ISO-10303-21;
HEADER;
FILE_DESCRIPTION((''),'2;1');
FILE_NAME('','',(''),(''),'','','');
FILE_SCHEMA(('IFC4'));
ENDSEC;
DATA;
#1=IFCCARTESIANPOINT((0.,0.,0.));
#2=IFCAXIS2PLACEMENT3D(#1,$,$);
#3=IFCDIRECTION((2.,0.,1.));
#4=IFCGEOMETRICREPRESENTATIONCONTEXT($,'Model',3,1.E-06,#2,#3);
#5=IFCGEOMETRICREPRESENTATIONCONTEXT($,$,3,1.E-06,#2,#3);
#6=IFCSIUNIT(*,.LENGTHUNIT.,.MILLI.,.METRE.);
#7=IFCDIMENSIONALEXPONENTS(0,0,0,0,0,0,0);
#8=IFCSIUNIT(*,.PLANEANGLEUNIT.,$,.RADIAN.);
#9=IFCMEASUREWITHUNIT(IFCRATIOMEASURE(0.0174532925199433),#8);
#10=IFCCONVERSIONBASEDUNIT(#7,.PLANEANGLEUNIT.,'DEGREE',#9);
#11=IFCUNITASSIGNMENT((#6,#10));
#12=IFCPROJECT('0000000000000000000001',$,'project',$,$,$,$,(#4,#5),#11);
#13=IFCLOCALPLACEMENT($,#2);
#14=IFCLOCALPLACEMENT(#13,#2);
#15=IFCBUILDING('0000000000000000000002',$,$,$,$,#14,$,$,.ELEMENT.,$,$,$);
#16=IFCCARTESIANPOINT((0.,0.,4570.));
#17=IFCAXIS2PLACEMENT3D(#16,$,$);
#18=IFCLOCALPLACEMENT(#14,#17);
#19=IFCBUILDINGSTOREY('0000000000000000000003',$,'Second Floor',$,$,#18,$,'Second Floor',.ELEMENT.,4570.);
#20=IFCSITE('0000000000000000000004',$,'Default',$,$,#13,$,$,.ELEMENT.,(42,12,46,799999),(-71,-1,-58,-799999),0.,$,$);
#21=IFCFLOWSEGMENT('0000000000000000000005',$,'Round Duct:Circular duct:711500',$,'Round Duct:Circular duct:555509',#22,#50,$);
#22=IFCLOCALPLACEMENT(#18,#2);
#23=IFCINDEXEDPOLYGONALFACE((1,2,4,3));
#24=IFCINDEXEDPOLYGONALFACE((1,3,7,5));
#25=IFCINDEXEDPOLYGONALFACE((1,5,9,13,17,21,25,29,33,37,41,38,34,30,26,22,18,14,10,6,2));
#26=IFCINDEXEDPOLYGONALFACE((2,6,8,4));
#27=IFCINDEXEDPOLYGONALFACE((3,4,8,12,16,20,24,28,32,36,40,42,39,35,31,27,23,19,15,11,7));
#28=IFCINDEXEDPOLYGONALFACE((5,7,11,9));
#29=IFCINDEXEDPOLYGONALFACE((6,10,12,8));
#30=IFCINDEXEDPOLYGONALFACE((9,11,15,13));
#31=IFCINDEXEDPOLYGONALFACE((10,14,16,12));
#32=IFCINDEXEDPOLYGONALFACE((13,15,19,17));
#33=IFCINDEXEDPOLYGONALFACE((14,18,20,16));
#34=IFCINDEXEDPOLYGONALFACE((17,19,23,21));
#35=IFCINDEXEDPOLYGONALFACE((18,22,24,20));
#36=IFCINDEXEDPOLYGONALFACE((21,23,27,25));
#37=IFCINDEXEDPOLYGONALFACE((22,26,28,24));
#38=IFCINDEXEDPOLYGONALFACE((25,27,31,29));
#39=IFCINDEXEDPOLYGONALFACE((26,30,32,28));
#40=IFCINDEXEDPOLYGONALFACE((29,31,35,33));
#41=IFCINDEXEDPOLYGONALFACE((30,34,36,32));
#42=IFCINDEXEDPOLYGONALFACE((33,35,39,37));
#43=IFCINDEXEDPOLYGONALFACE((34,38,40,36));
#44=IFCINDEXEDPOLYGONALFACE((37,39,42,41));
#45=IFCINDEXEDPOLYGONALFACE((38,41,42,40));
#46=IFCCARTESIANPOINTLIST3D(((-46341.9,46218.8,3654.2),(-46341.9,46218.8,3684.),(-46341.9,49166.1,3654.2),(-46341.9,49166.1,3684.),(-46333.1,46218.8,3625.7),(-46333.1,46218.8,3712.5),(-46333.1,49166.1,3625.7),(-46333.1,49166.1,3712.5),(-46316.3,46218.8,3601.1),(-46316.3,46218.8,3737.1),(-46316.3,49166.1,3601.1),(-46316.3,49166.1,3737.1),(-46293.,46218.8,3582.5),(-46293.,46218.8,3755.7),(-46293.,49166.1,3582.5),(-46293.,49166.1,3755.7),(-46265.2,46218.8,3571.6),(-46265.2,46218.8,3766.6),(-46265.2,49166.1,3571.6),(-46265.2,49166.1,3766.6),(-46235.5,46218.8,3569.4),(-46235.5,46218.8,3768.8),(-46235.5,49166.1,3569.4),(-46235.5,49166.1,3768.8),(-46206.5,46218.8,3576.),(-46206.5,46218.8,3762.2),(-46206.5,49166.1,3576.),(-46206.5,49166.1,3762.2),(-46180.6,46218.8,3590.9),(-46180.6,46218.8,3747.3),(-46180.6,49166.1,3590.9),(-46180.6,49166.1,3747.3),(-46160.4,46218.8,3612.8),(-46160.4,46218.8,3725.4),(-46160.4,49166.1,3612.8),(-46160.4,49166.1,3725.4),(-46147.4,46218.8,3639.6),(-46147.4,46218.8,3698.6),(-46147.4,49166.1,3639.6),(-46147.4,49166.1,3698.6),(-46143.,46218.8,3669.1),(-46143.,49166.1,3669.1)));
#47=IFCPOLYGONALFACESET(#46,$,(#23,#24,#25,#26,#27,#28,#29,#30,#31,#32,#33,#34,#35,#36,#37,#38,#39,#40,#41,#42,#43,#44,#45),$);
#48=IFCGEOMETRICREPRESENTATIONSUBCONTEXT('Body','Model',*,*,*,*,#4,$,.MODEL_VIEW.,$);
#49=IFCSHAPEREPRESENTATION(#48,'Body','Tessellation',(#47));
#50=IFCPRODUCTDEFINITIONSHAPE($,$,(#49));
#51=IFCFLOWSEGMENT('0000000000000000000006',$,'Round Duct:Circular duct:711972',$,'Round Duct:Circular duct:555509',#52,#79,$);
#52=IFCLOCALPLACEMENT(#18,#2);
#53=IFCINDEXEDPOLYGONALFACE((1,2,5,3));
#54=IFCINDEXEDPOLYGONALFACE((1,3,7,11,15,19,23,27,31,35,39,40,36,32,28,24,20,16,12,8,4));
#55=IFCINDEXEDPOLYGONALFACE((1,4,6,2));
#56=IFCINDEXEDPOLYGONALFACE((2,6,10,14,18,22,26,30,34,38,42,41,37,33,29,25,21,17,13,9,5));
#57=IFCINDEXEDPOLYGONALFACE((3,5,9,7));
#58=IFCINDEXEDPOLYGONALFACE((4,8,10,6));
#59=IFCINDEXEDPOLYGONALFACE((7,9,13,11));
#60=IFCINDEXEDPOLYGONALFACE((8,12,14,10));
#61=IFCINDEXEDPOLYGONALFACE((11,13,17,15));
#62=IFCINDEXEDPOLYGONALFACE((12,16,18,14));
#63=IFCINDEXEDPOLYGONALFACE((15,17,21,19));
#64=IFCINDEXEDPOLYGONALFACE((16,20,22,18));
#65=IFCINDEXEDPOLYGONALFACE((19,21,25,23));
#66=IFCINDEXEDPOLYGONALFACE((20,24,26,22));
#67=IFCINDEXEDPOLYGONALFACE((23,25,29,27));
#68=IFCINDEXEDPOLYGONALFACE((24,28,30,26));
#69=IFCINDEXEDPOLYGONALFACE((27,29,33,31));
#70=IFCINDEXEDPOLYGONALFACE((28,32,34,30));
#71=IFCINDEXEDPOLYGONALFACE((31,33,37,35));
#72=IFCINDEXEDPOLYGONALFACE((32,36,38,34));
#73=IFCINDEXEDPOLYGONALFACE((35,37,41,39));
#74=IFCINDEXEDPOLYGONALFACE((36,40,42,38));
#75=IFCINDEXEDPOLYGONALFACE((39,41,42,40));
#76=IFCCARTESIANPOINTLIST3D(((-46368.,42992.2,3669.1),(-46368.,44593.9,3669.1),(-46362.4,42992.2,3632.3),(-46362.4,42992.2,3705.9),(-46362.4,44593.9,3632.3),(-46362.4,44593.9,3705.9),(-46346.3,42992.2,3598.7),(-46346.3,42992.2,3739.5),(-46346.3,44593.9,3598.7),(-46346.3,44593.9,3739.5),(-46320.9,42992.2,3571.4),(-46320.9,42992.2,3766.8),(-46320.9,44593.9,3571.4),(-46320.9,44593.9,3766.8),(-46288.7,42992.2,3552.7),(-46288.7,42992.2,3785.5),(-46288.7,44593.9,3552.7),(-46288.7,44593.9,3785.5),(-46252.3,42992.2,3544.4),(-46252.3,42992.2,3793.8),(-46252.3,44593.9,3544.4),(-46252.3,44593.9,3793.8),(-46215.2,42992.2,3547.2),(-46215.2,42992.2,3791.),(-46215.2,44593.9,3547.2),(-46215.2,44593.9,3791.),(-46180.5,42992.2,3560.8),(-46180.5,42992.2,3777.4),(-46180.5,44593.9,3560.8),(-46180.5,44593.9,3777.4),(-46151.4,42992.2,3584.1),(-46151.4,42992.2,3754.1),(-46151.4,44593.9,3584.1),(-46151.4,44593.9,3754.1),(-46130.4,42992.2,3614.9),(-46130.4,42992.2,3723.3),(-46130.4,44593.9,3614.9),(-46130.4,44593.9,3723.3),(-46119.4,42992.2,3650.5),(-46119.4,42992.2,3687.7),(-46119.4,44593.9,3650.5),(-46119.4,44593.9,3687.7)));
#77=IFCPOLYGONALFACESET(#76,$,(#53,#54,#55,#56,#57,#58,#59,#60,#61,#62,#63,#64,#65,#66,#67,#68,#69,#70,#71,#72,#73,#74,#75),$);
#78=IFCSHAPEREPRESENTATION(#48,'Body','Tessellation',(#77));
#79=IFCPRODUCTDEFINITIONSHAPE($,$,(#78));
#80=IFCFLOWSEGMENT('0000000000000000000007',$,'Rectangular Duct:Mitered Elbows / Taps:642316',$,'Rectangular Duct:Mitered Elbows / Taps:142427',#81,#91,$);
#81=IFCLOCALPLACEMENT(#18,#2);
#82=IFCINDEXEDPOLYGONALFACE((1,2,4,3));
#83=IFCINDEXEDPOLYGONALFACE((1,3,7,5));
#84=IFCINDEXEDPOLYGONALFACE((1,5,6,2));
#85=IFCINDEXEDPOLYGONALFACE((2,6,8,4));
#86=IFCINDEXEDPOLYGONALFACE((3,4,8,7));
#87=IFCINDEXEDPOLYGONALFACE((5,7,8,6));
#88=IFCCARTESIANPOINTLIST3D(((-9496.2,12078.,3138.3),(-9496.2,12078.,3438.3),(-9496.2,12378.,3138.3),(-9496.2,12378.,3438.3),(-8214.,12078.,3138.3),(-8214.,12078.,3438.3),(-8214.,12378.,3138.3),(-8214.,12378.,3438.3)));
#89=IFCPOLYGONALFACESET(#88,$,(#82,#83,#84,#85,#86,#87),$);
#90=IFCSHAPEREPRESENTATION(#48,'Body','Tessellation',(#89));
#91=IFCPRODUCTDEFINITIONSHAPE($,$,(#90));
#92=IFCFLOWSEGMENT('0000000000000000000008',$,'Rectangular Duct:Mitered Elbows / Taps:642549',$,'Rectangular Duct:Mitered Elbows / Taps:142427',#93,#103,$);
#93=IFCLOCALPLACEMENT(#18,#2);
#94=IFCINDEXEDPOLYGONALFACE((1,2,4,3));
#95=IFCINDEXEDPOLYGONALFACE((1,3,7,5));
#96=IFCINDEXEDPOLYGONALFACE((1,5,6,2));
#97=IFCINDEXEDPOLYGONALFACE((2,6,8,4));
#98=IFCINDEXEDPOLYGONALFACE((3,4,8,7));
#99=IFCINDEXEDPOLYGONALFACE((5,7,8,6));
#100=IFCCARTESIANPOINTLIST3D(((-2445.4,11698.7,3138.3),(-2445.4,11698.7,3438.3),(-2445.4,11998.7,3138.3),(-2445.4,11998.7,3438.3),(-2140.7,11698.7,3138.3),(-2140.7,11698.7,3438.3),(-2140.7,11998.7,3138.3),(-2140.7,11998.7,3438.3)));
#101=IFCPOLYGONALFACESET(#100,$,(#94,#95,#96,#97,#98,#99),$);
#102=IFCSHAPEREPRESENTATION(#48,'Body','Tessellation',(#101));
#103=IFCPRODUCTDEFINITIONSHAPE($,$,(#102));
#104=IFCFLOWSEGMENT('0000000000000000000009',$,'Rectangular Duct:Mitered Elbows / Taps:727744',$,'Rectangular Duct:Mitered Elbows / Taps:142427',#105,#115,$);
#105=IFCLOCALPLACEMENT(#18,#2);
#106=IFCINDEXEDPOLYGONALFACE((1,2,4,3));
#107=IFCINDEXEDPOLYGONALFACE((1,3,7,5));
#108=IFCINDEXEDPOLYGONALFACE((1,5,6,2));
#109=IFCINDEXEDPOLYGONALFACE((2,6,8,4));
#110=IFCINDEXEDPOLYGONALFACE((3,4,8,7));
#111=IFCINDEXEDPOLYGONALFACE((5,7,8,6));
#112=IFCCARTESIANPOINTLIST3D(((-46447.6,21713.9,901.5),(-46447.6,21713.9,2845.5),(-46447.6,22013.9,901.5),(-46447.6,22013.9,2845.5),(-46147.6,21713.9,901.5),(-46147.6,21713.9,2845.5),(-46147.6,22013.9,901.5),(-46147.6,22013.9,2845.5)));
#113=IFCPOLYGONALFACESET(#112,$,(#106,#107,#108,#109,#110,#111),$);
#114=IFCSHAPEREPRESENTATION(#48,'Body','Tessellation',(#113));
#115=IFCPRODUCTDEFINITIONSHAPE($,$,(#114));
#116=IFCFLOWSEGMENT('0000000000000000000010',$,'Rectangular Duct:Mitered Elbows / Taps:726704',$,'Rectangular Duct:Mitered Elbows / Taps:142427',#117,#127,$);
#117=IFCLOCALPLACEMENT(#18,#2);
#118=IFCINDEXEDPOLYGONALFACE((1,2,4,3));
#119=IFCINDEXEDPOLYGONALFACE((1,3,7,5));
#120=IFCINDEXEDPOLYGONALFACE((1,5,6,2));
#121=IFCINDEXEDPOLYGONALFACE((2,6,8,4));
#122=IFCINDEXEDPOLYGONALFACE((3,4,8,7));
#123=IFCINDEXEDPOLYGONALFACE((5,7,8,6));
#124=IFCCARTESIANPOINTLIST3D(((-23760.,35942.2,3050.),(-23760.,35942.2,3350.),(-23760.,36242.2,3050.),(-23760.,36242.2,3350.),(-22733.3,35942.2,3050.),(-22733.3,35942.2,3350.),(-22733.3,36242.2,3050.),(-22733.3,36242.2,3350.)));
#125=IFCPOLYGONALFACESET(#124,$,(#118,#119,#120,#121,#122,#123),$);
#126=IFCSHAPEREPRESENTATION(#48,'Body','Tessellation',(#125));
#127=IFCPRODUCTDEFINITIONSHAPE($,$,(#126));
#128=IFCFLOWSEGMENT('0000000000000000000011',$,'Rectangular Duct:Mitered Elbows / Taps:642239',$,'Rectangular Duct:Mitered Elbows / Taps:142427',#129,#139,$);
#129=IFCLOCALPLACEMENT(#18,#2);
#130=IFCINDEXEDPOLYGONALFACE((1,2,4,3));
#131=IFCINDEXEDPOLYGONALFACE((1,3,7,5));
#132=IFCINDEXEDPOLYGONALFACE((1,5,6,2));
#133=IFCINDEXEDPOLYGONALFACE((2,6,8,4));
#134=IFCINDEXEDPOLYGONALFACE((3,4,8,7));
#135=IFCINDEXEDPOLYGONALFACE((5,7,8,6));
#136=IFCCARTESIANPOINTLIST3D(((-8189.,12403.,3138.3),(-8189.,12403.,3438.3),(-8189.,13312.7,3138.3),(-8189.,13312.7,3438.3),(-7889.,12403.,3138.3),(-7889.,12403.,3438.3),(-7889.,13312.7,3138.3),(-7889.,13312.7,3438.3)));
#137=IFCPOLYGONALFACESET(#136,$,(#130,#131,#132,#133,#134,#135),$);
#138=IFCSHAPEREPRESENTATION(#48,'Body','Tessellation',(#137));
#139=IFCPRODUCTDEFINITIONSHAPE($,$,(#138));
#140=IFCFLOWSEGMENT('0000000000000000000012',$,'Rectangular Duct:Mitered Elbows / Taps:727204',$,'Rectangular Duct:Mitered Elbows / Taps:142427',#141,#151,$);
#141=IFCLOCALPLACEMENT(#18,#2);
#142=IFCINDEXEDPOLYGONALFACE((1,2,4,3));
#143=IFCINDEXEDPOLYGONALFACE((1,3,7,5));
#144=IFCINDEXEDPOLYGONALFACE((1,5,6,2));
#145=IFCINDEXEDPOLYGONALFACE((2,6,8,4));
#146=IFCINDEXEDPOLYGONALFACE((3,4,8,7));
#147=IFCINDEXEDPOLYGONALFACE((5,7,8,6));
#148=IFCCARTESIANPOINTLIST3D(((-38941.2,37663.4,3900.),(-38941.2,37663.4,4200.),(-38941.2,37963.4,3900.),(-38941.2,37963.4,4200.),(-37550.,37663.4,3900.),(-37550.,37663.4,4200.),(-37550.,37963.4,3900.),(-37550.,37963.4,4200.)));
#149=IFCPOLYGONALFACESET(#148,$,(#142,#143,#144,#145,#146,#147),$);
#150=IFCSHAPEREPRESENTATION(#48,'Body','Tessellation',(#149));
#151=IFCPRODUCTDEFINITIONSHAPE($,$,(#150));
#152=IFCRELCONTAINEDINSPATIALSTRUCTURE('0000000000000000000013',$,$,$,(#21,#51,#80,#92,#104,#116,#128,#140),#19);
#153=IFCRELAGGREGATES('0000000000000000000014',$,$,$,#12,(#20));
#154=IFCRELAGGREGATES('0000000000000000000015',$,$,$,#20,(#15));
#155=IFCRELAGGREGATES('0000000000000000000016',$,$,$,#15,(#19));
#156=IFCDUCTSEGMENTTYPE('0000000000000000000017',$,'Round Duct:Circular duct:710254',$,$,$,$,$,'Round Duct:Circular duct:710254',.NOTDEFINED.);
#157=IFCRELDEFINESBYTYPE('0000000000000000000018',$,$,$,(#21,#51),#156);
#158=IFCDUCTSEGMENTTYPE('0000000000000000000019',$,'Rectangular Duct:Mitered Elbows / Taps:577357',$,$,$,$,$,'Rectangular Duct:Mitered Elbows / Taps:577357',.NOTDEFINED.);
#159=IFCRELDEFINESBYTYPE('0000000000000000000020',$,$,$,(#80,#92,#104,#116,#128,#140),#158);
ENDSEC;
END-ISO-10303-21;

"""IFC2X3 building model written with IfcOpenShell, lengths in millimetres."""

from ifc_helpers import new_model, entity, si_unit, converted_unit, direction, frame, frame_2d, origin, origin_2d_with_axis, place, context, subcontext, project, spatial, rectangle, circle, extrude, type_object, element, save


model = new_model("IFC2X3")

# Units and contexts
model_context = context("Model", 3, precision=1e-06, world=origin(), true_north=direction((2.0, 0.0, 1.0)))
context_of_model = context(None, 3, precision=1e-06, world=origin(), true_north=direction((2.0, 0.0, 1.0)))
body_context = subcontext(model_context, "Body", "Model", "MODEL_VIEW")
ifc_project = project(units=[si_unit("LENGTHUNIT", "METRE", prefix="MILLI"), converted_unit("PLANEANGLEUNIT", "DEGREE", entity("IfcRatioMeasure", 0.0174532925199433), si_unit("PLANEANGLEUNIT", "RADIAN"), dimensions=[0, 0, 0, 0, 0, 0, 0])], contexts=[model_context, context_of_model])

# Site, building, storey
site_placement = place(None, origin())
site = spatial("IfcSite", under=ifc_project, at=site_placement, Name="Default", CompositionType="ELEMENT", RefLatitude=(42, 12, 46, 799999), RefLongitude=(-71, -1, -58, -799999), RefElevation=0.0)
building_placement = place(site_placement, origin())
building = spatial("IfcBuilding", under=site, at=building_placement, CompositionType="ELEMENT")
storey_placement = place(building_placement, frame((0.0, 0.0, 4570.0)))
storey = spatial("IfcBuildingStorey", under=building, at=storey_placement, Name="Second Floor", LongName="Second Floor", CompositionType="ELEMENT", Elevation=4570.0)

# Flow segments
duct_segment_type_1 = type_object("IfcDuctSegmentType", Name="Round Duct:Circular duct:710254", ElementType="Round Duct:Circular duct:710254", PredefinedType="NOTDEFINED")
flow_segment_1_placement = place(storey_placement, origin())
element("IfcFlowSegment", 1, at=flow_segment_1_placement, inside=storey, type_object=duct_segment_type_1, Name="Round Duct:Circular duct:711500", ObjectType="Round Duct:Circular duct:555509", context=body_context, shape_type="SweptSolid", body=[
    extrude(circle(Radius=100.0, at=origin_2d_with_axis()), frame((-46243.0, 46218.8, 3669.1), z_axis=(0.0, 1.0, 0.0), x_axis=(1.0, 0.0, 0.0)), (0.0, 0.0, 1.0), 2947.3),
])
flow_segment_2_placement = place(storey_placement, origin())
element("IfcFlowSegment", 2, at=flow_segment_2_placement, inside=storey, type_object=duct_segment_type_1, Name="Round Duct:Circular duct:711972", ObjectType="Round Duct:Circular duct:555509", context=body_context, shape_type="SweptSolid", body=[
    extrude(circle(Radius=125.0, at=origin_2d_with_axis()), frame((-46243.0, 42992.2, 3669.1), z_axis=(0.0, 1.0, 0.0), x_axis=(-1.0, 0.0, 0.0)), (0.0, 0.0, 1.0), 1601.7),
])
duct_segment_type_2 = type_object("IfcDuctSegmentType", Name="Rectangular Duct:Mitered Elbows / Taps:577357", ElementType="Rectangular Duct:Mitered Elbows / Taps:577357", PredefinedType="NOTDEFINED")
flow_segment_3_placement = place(storey_placement, origin())
element("IfcFlowSegment", 3, at=flow_segment_3_placement, inside=storey, type_object=duct_segment_type_2, Name="Rectangular Duct:Mitered Elbows / Taps:642316", ObjectType="Rectangular Duct:Mitered Elbows / Taps:142427", context=body_context, shape_type="SweptSolid", body=[
    extrude(rectangle(XDim=1282.3, YDim=300.0, at=frame_2d((0.0, 0.0), x_axis=(1.0, 0.0))), frame((-8855.1, 12228.0, 3138.3)), (0.0, 0.0, 1.0), 300.0),
])
flow_segment_4_placement = place(storey_placement, origin())
element("IfcFlowSegment", 4, at=flow_segment_4_placement, inside=storey, type_object=duct_segment_type_2, Name="Rectangular Duct:Mitered Elbows / Taps:642549", ObjectType="Rectangular Duct:Mitered Elbows / Taps:142427", context=body_context, shape_type="SweptSolid", body=[
    extrude(rectangle(XDim=304.7, YDim=300.0, at=frame_2d((0.0, 0.0), x_axis=(1.0, 0.0))), frame((-2293.1, 11848.7, 3138.3), z_axis=(0.0, 0.000002, 1.0), x_axis=(-1.0, 0.0, 0.0)), (0.0, 0.0, 1.0), 300.0),
])
flow_segment_5_placement = place(storey_placement, origin())
element("IfcFlowSegment", 5, at=flow_segment_5_placement, inside=storey, type_object=duct_segment_type_2, Name="Rectangular Duct:Mitered Elbows / Taps:727744", ObjectType="Rectangular Duct:Mitered Elbows / Taps:142427", context=body_context, shape_type="SweptSolid", body=[
    extrude(rectangle(XDim=300.0, YDim=300.0, at=origin_2d_with_axis()), frame((-46297.6, 21863.9, 901.5), z_axis=(0.0, 0.0, 1.0), x_axis=(-1.0, 0.0, 0.0)), (0.0, 0.0, 1.0), 1944.0),
])
flow_segment_6_placement = place(storey_placement, origin())
element("IfcFlowSegment", 6, at=flow_segment_6_placement, inside=storey, type_object=duct_segment_type_2, Name="Rectangular Duct:Mitered Elbows / Taps:726704", ObjectType="Rectangular Duct:Mitered Elbows / Taps:142427", context=body_context, shape_type="SweptSolid", body=[
    extrude(rectangle(XDim=1026.7, YDim=300.0, at=origin_2d_with_axis()), frame((-23246.6, 36092.2, 3050.0), z_axis=(0.0, 0.0, 1.0), x_axis=(-1.0, 0.0, 0.0)), (0.0, 0.0, 1.0), 300.0),
])
flow_segment_7_placement = place(storey_placement, origin())
element("IfcFlowSegment", 7, at=flow_segment_7_placement, inside=storey, type_object=duct_segment_type_2, Name="Rectangular Duct:Mitered Elbows / Taps:642239", ObjectType="Rectangular Duct:Mitered Elbows / Taps:142427", context=body_context, shape_type="SweptSolid", body=[
    extrude(rectangle(XDim=909.7, YDim=300.0, at=frame_2d((0.0, 0.0), x_axis=(1.0, 0.0))), frame((-8039.0, 12857.9, 3138.3), z_axis=(0.0, 0.0, 1.0), x_axis=(0.0, -1.0, 0.0)), (0.0, 0.0, 1.0), 300.0),
])
flow_segment_8_placement = place(storey_placement, origin())
element("IfcFlowSegment", 8, at=flow_segment_8_placement, inside=storey, type_object=duct_segment_type_2, Name="Rectangular Duct:Mitered Elbows / Taps:727204", ObjectType="Rectangular Duct:Mitered Elbows / Taps:142427", context=body_context, shape_type="SweptSolid", body=[
    extrude(rectangle(XDim=1391.2, YDim=300.0, at=origin_2d_with_axis()), frame((-38245.6, 37813.4, 3900.0)), (0.0, 0.0, 1.0), 300.0),
])

save(model, "model.ifc")
